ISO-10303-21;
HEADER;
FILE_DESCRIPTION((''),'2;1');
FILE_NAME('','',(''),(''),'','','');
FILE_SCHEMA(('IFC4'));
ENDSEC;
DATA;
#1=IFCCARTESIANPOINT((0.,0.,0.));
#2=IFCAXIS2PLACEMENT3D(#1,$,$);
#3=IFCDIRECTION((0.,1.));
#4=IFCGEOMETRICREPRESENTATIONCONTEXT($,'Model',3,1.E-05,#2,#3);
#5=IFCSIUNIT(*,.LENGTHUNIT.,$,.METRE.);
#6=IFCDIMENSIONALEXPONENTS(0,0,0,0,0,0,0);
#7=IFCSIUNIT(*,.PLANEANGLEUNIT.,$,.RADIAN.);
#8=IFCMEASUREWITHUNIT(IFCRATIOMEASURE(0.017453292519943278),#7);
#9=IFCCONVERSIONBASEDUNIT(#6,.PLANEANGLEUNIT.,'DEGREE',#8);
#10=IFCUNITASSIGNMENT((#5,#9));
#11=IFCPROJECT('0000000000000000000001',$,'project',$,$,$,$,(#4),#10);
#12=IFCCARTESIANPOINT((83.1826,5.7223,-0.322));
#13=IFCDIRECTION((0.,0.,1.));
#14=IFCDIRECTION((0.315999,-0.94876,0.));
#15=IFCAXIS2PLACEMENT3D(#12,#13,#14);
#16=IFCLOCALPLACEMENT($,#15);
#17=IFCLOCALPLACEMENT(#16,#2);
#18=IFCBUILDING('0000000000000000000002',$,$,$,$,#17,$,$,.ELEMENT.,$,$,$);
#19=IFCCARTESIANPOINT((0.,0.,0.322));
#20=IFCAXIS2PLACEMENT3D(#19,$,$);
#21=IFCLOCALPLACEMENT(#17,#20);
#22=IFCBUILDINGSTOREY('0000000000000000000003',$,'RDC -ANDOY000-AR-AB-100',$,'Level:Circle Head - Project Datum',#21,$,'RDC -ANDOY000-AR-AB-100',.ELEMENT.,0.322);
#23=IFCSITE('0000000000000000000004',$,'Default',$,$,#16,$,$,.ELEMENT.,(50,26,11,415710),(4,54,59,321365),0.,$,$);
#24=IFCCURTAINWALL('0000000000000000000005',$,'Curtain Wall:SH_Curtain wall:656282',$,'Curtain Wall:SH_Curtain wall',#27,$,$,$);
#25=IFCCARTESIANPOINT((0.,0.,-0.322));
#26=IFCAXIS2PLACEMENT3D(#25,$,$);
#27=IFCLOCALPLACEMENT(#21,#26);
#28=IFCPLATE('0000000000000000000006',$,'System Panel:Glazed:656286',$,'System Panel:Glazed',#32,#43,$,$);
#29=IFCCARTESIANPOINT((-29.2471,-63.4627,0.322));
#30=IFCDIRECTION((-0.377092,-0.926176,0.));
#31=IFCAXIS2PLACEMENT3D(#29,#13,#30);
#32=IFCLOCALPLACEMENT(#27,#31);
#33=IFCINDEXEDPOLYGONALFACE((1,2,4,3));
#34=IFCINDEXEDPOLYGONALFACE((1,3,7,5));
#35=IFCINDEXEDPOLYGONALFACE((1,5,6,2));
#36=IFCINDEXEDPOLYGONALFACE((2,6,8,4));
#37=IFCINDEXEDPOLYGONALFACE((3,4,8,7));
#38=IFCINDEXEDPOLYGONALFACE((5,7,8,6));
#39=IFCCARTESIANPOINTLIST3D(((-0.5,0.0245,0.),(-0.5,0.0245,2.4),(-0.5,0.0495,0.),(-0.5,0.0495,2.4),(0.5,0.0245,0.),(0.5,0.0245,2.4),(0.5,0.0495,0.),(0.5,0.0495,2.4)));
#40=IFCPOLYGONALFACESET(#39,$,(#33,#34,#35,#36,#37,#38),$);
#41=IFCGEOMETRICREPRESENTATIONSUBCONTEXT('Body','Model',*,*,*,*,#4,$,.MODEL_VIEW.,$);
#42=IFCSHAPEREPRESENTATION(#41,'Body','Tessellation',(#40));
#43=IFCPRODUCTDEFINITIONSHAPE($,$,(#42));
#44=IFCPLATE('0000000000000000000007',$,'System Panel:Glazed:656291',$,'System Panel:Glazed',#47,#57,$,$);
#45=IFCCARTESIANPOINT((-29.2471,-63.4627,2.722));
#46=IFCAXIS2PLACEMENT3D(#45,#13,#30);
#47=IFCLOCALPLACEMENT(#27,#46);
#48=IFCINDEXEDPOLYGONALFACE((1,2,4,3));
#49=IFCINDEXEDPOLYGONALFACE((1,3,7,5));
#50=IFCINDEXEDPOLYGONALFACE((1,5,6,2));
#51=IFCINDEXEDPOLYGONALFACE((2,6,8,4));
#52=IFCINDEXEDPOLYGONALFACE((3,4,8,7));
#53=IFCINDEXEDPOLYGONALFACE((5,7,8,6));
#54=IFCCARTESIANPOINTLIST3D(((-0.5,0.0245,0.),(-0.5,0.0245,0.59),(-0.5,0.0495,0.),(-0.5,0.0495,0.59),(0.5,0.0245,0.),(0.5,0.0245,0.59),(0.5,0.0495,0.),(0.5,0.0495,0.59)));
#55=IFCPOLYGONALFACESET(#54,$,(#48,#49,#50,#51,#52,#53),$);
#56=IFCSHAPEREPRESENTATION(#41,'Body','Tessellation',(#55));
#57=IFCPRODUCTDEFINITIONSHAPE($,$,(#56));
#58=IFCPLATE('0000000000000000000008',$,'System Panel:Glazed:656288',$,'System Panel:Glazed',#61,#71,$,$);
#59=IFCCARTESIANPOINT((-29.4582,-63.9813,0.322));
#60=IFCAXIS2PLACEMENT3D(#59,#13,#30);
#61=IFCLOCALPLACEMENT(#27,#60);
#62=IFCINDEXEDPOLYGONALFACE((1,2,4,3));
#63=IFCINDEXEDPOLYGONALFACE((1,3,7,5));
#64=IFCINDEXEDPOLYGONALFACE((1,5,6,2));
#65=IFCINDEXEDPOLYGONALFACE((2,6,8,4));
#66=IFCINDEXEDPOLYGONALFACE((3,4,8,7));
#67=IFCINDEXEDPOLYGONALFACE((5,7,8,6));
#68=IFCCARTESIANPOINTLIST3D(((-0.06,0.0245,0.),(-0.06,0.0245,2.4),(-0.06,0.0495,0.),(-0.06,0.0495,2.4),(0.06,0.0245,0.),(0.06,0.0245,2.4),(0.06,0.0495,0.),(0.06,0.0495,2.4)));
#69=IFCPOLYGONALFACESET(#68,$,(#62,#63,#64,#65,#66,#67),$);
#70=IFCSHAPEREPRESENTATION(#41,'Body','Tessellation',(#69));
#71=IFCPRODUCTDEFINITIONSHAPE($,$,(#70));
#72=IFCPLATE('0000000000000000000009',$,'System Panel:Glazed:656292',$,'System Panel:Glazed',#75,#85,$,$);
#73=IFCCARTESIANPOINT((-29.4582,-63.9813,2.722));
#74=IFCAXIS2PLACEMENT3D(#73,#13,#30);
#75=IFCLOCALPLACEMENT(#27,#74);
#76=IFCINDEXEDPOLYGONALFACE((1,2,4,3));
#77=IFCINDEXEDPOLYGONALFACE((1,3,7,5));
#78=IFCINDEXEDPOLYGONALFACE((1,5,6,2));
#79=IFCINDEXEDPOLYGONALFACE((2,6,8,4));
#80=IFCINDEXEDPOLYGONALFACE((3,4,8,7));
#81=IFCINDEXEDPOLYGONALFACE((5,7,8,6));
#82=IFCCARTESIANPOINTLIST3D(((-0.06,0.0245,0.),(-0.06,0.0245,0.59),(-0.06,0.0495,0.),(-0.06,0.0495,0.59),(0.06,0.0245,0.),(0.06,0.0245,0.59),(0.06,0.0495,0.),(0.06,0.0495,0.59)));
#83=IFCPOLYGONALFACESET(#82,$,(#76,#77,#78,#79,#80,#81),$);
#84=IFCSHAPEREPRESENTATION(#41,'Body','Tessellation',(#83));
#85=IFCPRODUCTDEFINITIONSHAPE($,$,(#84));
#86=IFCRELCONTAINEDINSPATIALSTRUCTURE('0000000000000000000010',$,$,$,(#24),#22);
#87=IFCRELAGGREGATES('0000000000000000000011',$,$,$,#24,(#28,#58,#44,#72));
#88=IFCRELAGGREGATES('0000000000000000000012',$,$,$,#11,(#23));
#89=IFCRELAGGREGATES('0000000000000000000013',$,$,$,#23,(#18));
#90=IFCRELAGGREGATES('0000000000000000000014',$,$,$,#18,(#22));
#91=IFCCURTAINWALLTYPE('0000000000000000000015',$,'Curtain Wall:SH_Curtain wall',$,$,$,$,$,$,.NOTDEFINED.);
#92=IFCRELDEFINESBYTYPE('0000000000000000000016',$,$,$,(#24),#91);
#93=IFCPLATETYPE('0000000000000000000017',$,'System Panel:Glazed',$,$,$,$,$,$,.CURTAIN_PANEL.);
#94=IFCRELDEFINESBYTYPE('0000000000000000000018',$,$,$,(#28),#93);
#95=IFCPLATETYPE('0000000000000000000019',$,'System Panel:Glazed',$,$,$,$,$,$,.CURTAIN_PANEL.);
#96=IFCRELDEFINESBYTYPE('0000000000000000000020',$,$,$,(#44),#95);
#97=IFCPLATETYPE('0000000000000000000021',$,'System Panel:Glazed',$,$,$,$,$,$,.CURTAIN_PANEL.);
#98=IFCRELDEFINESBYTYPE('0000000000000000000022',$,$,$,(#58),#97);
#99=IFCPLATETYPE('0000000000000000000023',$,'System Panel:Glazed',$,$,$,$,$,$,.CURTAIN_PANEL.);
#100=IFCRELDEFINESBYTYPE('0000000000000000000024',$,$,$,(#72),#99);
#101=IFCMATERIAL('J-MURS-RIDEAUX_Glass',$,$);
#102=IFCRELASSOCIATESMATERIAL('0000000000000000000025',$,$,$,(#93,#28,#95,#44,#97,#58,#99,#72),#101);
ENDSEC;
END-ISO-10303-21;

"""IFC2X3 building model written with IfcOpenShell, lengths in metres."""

from ifc_helpers import new_model, entity, si_unit, converted_unit, direction, frame, frame_2d, origin, place, context, subcontext, project, spatial, rectangle, extrude, source, transform, mapped, material, type_object, type_shapes, element, aggregate, save


model = new_model("IFC2X3")

# Units and contexts
model_context = context("Model", 3, precision=1e-05, world=origin(), true_north=direction((0.0, 1.0)))
body_context = subcontext(model_context, "Body", "Model", "MODEL_VIEW")
ifc_project = project(units=[si_unit("LENGTHUNIT", "METRE"), converted_unit("PLANEANGLEUNIT", "DEGREE", entity("IfcRatioMeasure", 0.017453292519943278), si_unit("PLANEANGLEUNIT", "RADIAN"), dimensions=[0, 0, 0, 0, 0, 0, 0])], contexts=[model_context])

# Site, building, storey
site_placement = place(None, frame((83.1826, 5.7223, -0.322), z_axis=(0.0, 0.0, 1.0), x_axis=(0.315999, -0.94876, 0.0)))
site = spatial("IfcSite", under=ifc_project, at=site_placement, Name="Default", CompositionType="ELEMENT", RefLatitude=(50, 26, 11, 415710), RefLongitude=(4, 54, 59, 321365), RefElevation=0.0)
building_placement = place(site_placement, origin())
building = spatial("IfcBuilding", under=site, at=building_placement, CompositionType="ELEMENT")
storey_placement = place(building_placement, frame((0.0, 0.0, 0.322)))
storey = spatial("IfcBuildingStorey", under=building, at=storey_placement, Name="RDC -ANDOY000-AR-AB-100", ObjectType="Level:Circle Head - Project Datum", LongName="RDC -ANDOY000-AR-AB-100", CompositionType="ELEMENT", Elevation=0.322)

# Shared definitions
curtain_wall_type = type_object("IfcCurtainWallType", Name="Curtain Wall:SH_Curtain wall", PredefinedType="NOTDEFINED")

# Curtain wall
curtain_wall_1_placement = place(storey_placement, frame((0.0, 0.0, -0.322)))
curtain_wall_1 = element("IfcCurtainWall", 1, at=curtain_wall_1_placement, inside=storey, type_object=curtain_wall_type, Name="Curtain Wall:SH_Curtain wall:656282", ObjectType="Curtain Wall:SH_Curtain wall")

# Plates
ifc_material_1 = material(Name="J-MURS-RIDEAUX_Glass")
plate_type_1 = type_object("IfcPlateType", Name="System Panel:Glazed", PredefinedType="CURTAIN_PANEL", material=ifc_material_1)
shared_shape_1 = source(origin(), body_context, "Body", "SweptSolid", [
    extrude(rectangle(XDim=0.025, YDim=1.0, at=frame_2d((0.0, 0.0), x_axis=(1.0, 0.0))), frame((0.0, 0.037, 0.0), z_axis=(0.0, 0.0, 1.0), x_axis=(0.0, 1.0, 0.0)), (0.0, 0.0, 1.0), 2.4),
])
type_shapes(plate_type_1, [shared_shape_1])
plate_1_placement = place(curtain_wall_1_placement, frame((-29.2471, -63.4627, 0.322), z_axis=(0.0, 0.0, 1.0), x_axis=(-0.377092, -0.926176, 0.0)))
plate_1 = element("IfcPlate", 2, at=plate_1_placement, type_object=plate_type_1, material=ifc_material_1, Name="System Panel:Glazed:656286", ObjectType="System Panel:Glazed", context=body_context, shape_type="MappedRepresentation", body=[
    mapped(shared_shape_1, transform((0.0, 0.0, 0.0), scale=1.0)),
])
plate_type_2 = type_object("IfcPlateType", Name="System Panel:Glazed", PredefinedType="CURTAIN_PANEL", material=ifc_material_1)
shared_shape_2 = source(origin(), body_context, "Body", "SweptSolid", [
    extrude(rectangle(XDim=0.025, YDim=1.0, at=frame_2d((0.0, 0.0), x_axis=(1.0, 0.0))), frame((0.0, 0.037, 0.0), z_axis=(0.0, 0.0, 1.0), x_axis=(0.0, 1.0, 0.0)), (0.0, 0.0, 1.0), 0.59),
])
type_shapes(plate_type_2, [shared_shape_2])
plate_2_placement = place(curtain_wall_1_placement, frame((-29.2471, -63.4627, 2.722), z_axis=(0.0, 0.0, 1.0), x_axis=(-0.377092, -0.926176, 0.0)))
plate_2 = element("IfcPlate", 3, at=plate_2_placement, type_object=plate_type_2, material=ifc_material_1, Name="System Panel:Glazed:656291", ObjectType="System Panel:Glazed", context=body_context, shape_type="MappedRepresentation", body=[
    mapped(shared_shape_2, transform((0.0, 0.0, 0.0), scale=1.0)),
])
plate_type_3 = type_object("IfcPlateType", Name="System Panel:Glazed", PredefinedType="CURTAIN_PANEL", material=ifc_material_1)
shared_shape_3 = source(origin(), body_context, "Body", "SweptSolid", [
    extrude(rectangle(XDim=0.025, YDim=0.12, at=frame_2d((0.0, 0.0), x_axis=(1.0, 0.0))), frame((0.0, 0.037, 0.0), z_axis=(0.0, 0.0, 1.0), x_axis=(0.0, 1.0, 0.0)), (0.0, 0.0, 1.0), 2.4),
])
type_shapes(plate_type_3, [shared_shape_3])
plate_3_placement = place(curtain_wall_1_placement, frame((-29.4582, -63.9813, 0.322), z_axis=(0.0, 0.0, 1.0), x_axis=(-0.377092, -0.926176, 0.0)))
plate_3 = element("IfcPlate", 4, at=plate_3_placement, type_object=plate_type_3, material=ifc_material_1, Name="System Panel:Glazed:656288", ObjectType="System Panel:Glazed", context=body_context, shape_type="MappedRepresentation", body=[
    mapped(shared_shape_3, transform((0.0, 0.0, 0.0), scale=1.0)),
])
plate_type_4 = type_object("IfcPlateType", Name="System Panel:Glazed", PredefinedType="CURTAIN_PANEL", material=ifc_material_1)
shared_shape_4 = source(origin(), body_context, "Body", "SweptSolid", [
    extrude(rectangle(XDim=0.025, YDim=0.12, at=frame_2d((0.0, 0.0), x_axis=(1.0, 0.0))), frame((0.0, 0.037, 0.0), z_axis=(0.0, 0.0, 1.0), x_axis=(0.0, 1.0, 0.0)), (0.0, 0.0, 1.0), 0.59),
])
type_shapes(plate_type_4, [shared_shape_4])
plate_4_placement = place(curtain_wall_1_placement, frame((-29.4582, -63.9813, 2.722), z_axis=(0.0, 0.0, 1.0), x_axis=(-0.377092, -0.926176, 0.0)))
plate_4 = element("IfcPlate", 5, at=plate_4_placement, type_object=plate_type_4, material=ifc_material_1, Name="System Panel:Glazed:656292", ObjectType="System Panel:Glazed", context=body_context, shape_type="MappedRepresentation", body=[
    mapped(shared_shape_4, transform((0.0, 0.0, 0.0), scale=1.0)),
])
aggregate(curtain_wall_1, [plate_1, plate_3, plate_2, plate_4])

save(model, "model.ifc")
